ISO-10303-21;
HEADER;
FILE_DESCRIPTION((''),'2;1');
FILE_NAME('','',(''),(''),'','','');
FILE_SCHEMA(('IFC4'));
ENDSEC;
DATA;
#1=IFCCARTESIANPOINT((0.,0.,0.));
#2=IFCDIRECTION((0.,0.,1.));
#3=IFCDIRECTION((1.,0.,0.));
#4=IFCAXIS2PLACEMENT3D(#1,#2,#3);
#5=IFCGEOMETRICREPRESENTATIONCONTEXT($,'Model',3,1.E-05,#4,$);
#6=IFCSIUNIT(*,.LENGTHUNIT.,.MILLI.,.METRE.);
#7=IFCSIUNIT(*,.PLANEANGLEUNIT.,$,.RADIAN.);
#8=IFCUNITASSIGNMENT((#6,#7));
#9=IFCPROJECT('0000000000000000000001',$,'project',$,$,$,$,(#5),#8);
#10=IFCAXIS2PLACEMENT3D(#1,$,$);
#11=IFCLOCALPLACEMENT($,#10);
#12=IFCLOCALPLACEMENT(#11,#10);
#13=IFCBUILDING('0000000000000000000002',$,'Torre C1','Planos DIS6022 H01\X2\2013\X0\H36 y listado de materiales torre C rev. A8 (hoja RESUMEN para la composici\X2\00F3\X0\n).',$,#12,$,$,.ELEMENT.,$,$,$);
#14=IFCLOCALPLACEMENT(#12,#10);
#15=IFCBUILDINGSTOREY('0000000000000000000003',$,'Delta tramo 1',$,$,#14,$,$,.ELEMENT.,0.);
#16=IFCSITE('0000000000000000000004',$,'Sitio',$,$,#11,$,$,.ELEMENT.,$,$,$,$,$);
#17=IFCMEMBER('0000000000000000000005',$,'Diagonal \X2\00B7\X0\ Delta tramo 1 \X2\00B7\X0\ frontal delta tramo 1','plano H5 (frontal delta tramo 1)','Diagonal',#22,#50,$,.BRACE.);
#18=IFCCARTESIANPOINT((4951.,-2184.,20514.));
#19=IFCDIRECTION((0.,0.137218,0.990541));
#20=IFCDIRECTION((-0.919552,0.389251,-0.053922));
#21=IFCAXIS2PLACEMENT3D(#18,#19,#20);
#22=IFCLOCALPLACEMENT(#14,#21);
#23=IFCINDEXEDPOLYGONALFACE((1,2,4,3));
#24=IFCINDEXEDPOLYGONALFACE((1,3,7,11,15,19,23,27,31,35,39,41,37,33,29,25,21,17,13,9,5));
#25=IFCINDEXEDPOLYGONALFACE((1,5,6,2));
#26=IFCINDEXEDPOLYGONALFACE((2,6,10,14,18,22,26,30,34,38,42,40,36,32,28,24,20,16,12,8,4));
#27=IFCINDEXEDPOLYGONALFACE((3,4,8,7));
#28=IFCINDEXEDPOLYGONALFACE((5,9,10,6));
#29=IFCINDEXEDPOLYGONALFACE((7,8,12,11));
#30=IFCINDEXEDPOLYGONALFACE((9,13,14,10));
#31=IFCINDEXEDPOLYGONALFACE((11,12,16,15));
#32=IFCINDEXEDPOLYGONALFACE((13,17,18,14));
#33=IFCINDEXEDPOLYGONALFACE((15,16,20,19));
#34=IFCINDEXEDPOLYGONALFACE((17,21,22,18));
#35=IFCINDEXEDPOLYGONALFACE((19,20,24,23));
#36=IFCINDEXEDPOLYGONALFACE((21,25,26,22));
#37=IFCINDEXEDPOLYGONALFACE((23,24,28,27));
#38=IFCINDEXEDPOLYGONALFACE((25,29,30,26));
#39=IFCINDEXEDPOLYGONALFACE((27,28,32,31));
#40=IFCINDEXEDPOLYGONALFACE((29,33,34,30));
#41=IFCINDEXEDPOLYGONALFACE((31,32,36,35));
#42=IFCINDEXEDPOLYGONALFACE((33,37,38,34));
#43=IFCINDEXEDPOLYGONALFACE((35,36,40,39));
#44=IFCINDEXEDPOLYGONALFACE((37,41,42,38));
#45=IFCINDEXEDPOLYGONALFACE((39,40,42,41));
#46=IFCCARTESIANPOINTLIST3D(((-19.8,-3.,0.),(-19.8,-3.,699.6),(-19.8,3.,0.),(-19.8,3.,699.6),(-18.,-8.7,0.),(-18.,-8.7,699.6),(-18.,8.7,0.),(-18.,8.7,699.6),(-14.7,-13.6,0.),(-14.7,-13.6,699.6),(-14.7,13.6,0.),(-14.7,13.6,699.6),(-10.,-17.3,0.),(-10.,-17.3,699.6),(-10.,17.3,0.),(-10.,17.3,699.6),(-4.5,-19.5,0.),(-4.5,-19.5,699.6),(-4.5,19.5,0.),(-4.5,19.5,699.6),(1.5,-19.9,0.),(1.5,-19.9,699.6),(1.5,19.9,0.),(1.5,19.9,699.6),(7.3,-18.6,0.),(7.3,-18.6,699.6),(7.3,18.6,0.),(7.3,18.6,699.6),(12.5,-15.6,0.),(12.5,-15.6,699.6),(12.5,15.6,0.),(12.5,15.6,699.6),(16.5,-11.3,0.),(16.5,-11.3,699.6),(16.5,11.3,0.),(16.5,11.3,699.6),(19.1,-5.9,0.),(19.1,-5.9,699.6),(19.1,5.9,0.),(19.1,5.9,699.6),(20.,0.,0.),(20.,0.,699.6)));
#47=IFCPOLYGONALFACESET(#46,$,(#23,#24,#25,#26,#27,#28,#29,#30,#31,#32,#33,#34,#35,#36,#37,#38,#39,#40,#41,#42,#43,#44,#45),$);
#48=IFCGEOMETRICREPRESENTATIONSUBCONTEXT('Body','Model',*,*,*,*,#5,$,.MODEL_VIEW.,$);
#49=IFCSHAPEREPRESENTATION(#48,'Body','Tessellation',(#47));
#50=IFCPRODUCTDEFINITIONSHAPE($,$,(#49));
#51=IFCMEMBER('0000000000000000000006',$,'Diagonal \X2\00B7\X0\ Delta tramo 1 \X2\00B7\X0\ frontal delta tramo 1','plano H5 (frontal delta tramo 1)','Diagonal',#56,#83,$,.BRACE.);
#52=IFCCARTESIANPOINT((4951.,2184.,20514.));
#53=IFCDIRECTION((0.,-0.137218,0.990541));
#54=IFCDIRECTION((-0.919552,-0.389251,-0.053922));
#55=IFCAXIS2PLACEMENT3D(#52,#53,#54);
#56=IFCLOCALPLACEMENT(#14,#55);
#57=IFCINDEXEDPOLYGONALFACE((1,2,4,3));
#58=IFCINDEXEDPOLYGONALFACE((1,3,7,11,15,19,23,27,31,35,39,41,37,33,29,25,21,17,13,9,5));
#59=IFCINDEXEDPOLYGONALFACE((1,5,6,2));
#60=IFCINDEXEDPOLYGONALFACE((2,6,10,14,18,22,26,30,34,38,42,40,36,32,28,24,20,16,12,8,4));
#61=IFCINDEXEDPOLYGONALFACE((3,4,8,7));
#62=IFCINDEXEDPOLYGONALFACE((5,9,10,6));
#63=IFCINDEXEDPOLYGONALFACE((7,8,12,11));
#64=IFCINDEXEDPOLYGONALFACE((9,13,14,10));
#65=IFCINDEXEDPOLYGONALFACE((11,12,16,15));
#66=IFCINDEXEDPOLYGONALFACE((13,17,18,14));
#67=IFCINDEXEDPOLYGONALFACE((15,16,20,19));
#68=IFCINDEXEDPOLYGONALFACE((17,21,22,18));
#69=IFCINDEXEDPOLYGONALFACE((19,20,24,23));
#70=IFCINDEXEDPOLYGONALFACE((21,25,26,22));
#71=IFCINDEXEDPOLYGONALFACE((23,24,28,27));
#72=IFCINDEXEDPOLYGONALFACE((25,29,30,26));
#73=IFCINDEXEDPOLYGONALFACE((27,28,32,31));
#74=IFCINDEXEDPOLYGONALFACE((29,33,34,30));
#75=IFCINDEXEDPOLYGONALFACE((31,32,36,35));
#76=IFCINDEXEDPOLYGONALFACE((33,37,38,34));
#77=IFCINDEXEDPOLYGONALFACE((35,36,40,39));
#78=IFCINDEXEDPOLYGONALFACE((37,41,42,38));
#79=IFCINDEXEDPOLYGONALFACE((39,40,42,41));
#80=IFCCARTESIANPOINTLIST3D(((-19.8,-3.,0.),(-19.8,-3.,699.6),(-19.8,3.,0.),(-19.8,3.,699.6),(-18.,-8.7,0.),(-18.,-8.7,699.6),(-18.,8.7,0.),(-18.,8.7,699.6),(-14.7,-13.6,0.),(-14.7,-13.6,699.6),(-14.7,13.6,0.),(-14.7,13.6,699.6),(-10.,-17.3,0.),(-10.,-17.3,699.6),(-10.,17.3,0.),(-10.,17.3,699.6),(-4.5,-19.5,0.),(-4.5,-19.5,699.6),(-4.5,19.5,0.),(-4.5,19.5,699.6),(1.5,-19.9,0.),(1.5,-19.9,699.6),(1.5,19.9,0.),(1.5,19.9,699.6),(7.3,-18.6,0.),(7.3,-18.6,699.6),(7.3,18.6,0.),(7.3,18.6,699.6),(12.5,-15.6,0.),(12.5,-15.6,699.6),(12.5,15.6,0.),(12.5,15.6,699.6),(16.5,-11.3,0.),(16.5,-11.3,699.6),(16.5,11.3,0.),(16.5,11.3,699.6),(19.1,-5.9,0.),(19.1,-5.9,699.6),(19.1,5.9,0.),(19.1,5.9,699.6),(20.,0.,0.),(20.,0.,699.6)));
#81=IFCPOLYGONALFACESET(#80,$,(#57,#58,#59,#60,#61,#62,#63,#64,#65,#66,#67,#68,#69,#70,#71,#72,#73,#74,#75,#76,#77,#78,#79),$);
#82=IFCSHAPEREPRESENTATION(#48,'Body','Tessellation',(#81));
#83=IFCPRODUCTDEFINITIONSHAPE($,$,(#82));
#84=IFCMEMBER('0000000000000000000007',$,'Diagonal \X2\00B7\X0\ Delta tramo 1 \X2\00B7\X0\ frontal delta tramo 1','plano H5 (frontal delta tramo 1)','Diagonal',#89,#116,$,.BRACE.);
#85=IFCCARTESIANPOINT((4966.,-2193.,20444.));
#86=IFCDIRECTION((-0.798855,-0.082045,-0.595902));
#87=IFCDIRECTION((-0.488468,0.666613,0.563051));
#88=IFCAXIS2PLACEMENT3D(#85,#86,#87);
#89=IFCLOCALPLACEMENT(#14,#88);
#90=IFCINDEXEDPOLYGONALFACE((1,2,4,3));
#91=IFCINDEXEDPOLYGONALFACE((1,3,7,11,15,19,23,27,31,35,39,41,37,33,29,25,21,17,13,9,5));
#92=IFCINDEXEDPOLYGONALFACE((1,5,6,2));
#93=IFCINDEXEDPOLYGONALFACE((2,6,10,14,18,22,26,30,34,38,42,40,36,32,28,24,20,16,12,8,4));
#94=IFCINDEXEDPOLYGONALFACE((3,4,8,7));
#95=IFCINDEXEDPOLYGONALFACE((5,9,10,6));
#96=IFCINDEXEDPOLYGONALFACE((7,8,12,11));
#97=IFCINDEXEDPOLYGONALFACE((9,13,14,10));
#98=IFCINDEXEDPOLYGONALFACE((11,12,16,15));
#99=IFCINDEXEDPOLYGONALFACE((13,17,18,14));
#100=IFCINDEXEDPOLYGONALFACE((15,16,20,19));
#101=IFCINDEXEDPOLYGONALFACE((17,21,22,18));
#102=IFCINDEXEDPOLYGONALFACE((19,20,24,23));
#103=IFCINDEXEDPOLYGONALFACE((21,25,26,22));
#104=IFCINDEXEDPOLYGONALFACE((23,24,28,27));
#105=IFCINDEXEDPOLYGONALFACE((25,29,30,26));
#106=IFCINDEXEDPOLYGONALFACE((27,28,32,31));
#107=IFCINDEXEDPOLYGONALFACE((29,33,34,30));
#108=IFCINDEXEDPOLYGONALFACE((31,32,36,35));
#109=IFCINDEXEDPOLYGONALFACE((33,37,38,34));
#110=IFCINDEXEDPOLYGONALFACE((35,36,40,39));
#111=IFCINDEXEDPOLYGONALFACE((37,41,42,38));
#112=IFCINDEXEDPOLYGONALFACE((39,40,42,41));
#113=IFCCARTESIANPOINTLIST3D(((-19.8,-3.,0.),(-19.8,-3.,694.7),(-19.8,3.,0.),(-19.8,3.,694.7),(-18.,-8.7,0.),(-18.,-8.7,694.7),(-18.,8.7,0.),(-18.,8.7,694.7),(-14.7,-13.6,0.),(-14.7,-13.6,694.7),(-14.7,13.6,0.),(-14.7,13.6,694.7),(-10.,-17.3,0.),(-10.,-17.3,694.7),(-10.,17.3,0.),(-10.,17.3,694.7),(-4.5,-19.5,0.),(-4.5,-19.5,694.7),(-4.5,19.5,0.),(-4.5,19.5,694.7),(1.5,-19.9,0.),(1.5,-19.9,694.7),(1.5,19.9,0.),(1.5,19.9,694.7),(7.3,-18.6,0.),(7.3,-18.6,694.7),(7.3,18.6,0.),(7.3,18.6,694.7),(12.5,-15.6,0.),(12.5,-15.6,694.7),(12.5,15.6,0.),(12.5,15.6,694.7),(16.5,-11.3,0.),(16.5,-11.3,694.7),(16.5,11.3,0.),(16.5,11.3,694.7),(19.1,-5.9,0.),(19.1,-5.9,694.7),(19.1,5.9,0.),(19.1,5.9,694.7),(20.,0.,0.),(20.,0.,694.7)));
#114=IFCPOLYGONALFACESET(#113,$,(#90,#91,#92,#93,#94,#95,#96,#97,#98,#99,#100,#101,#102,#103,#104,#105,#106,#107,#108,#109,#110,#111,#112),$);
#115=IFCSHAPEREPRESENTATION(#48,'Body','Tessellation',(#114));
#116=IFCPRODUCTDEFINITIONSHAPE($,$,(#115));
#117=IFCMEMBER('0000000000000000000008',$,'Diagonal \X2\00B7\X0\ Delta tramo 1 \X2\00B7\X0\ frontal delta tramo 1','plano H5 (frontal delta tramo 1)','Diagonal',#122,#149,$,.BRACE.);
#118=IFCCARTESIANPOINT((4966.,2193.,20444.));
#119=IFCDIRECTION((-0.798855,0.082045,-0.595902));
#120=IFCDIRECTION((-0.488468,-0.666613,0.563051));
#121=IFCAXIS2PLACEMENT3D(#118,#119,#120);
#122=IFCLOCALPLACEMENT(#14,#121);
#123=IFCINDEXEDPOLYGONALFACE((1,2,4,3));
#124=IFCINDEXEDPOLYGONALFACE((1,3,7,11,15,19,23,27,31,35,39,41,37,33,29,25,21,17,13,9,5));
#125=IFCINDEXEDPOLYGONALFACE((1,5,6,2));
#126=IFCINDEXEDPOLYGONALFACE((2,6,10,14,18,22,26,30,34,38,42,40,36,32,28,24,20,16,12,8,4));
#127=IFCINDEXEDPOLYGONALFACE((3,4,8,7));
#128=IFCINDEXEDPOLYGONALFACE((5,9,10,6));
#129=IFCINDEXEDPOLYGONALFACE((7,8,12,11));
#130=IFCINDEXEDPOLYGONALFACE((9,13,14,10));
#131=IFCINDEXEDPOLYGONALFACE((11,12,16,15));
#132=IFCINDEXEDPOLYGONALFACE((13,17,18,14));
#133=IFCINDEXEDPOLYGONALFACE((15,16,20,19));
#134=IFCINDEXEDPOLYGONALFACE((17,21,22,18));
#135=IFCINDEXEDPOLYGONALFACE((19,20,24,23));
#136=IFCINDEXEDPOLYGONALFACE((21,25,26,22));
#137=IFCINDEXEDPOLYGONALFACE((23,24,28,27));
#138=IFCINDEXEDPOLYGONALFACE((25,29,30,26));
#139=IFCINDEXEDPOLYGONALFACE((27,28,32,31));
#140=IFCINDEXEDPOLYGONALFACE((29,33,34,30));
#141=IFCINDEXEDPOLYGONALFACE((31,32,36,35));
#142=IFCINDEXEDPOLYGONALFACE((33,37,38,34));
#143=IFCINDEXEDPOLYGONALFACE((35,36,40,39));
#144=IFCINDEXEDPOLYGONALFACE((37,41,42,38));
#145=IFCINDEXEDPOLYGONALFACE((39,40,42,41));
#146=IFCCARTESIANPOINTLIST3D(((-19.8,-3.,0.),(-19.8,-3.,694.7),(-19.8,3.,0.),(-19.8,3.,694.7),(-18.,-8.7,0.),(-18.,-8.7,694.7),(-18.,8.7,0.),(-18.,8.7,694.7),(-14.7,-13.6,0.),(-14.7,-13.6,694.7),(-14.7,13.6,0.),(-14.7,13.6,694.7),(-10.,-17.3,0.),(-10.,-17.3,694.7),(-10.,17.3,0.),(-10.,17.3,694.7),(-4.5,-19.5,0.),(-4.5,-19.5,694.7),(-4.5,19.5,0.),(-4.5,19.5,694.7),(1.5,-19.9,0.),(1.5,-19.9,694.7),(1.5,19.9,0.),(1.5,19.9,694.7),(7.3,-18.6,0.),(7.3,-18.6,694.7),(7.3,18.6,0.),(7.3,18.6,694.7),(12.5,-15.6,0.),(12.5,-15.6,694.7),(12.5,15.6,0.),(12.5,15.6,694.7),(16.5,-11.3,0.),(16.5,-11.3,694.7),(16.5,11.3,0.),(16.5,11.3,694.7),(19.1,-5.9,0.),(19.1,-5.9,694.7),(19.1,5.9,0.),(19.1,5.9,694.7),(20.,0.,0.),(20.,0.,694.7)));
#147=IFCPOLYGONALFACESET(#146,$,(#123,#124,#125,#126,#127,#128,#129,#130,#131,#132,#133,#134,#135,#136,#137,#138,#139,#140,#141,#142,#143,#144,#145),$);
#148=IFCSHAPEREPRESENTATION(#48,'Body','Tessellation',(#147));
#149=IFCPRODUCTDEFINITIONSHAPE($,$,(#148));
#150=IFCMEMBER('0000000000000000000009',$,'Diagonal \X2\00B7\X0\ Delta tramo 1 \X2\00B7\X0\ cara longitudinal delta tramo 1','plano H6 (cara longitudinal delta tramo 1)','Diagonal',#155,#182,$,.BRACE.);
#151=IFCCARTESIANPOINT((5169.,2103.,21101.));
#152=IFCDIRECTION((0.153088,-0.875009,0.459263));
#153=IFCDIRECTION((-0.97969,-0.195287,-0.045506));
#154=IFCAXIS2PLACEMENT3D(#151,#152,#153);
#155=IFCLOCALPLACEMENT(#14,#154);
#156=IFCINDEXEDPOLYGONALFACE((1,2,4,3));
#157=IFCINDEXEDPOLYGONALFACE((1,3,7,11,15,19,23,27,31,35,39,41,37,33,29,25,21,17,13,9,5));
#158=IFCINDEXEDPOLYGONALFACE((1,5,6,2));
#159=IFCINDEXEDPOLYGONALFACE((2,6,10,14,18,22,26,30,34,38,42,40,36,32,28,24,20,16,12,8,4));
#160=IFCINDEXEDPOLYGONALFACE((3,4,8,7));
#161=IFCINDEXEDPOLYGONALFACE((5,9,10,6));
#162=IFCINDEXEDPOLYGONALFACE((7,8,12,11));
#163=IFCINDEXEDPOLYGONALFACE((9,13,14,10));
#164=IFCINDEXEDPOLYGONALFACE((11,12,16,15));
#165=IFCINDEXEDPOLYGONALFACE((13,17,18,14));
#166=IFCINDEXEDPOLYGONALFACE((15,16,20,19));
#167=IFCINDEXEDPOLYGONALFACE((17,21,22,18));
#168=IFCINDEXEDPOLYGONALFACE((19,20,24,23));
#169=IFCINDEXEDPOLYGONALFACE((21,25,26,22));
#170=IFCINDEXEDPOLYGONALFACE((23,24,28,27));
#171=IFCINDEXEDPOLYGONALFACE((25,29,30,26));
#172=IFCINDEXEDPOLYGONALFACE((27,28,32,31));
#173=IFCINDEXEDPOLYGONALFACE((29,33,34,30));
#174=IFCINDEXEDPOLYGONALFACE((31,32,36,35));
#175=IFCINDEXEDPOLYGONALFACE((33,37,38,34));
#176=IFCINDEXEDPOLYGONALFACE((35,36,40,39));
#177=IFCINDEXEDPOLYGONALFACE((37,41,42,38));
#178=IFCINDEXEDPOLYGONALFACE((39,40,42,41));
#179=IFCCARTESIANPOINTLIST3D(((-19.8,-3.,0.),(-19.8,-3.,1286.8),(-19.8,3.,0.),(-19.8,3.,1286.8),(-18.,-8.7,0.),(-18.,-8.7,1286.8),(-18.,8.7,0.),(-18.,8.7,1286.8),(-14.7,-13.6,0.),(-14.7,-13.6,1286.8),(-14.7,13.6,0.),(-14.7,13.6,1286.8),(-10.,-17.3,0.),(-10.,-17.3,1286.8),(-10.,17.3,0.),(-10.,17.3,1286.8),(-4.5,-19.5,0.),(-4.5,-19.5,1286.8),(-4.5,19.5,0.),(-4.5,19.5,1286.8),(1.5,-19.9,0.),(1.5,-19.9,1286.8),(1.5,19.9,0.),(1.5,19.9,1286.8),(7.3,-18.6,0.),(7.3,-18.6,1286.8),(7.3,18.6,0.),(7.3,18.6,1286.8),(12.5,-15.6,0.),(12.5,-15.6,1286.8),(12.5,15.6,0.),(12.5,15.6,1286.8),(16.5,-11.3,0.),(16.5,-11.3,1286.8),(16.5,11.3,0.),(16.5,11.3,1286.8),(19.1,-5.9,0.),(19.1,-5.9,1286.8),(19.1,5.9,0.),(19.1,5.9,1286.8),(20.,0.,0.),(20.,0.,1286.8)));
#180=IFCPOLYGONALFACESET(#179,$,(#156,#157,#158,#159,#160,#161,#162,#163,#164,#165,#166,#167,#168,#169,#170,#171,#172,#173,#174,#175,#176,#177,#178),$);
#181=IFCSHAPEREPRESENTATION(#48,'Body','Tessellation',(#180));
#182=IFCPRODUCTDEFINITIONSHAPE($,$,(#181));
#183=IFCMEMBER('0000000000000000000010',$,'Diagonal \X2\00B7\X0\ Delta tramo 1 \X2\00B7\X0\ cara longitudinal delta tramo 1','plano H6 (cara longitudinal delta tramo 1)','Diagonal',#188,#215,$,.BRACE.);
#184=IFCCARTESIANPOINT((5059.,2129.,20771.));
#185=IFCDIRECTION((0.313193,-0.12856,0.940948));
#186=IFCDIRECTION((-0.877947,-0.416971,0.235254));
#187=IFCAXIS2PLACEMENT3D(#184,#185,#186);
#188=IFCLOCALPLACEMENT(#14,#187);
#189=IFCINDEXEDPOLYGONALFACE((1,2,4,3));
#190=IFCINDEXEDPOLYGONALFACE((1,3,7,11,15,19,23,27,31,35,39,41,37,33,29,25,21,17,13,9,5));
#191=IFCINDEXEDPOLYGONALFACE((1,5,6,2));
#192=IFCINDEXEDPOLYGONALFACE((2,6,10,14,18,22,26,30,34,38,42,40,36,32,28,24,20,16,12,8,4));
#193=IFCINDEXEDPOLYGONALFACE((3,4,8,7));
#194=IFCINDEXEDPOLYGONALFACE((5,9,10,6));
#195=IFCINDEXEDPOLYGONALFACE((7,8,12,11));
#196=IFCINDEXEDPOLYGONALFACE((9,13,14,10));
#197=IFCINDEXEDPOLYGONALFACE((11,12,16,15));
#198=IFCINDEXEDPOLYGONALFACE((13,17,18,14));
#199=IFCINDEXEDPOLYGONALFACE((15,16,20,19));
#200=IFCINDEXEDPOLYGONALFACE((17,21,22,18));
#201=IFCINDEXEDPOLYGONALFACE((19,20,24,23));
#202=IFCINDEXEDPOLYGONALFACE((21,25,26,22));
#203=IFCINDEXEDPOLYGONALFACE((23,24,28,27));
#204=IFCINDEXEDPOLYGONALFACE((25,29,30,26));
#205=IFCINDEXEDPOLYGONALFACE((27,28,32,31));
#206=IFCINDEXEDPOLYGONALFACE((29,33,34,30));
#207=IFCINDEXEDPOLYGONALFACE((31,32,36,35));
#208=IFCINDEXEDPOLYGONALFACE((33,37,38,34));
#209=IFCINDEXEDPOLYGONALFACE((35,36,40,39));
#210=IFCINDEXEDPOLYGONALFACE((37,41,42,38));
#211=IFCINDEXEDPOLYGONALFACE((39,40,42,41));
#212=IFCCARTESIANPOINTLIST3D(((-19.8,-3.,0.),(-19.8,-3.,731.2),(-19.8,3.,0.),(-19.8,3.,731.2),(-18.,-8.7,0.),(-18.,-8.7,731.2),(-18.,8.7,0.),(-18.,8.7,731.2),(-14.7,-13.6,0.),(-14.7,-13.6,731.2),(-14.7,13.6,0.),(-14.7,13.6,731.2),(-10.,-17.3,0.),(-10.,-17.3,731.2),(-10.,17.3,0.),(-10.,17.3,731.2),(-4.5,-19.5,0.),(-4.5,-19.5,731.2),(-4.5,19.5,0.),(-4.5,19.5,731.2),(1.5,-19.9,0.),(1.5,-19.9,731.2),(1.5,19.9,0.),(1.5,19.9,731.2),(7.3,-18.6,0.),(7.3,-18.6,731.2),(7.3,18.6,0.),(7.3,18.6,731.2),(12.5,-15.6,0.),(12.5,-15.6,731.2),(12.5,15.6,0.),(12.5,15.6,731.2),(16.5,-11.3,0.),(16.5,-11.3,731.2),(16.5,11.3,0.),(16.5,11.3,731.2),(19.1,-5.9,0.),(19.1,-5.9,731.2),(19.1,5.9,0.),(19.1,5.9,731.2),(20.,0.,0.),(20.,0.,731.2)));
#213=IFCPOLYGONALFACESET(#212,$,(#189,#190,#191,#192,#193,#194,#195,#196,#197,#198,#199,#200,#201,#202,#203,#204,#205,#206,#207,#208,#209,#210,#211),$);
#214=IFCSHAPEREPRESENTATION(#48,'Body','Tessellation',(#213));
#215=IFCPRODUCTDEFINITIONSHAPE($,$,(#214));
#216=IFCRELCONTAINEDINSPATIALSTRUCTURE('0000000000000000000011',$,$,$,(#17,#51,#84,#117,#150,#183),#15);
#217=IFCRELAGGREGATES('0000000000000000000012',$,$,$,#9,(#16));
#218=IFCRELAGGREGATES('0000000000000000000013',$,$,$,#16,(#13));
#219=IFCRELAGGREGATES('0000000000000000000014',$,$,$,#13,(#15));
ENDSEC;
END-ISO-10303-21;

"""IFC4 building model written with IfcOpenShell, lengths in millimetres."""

from ifc_helpers import new_model, si_unit, frame, origin, origin_with_axes, place, context, subcontext, project, spatial, circle, extrude, element, save


model = new_model("IFC4")

# Units and contexts
model_context = context("Model", 3, precision=1e-05, world=origin_with_axes())
body_context = subcontext(model_context, "Body", "Model", "MODEL_VIEW")
ifc_project = project(units=[si_unit("LENGTHUNIT", "METRE", prefix="MILLI"), si_unit("PLANEANGLEUNIT", "RADIAN")], contexts=[model_context])

# Site, building, storey
site_placement = place(None, origin())
site = spatial("IfcSite", under=ifc_project, at=site_placement, Name="Sitio", CompositionType="ELEMENT")
building_placement = place(site_placement, origin())
building = spatial("IfcBuilding", under=site, at=building_placement, Name="Torre C1", Description="Planos DIS6022 H01–H36 y listado de materiales torre C rev. A8 (hoja RESUMEN para la composición).", CompositionType="ELEMENT")
storey_placement = place(building_placement, origin())
storey = spatial("IfcBuildingStorey", under=building, at=storey_placement, Name="Delta tramo 1", CompositionType="ELEMENT", Elevation=0.0)

# Members
for number, where, z_axis, x_axis, name in (
    (1, (4951.0, -2184.0, 20514.0), (0.0, 0.137218, 0.990541), (-0.919552, 0.389251, -0.053922), "Diagonal · Delta tramo 1 · frontal delta tramo 1"),
    (2, (4951.0, 2184.0, 20514.0), (0.0, -0.137218, 0.990541), (-0.919552, -0.389251, -0.053922), "Diagonal · Delta tramo 1 · frontal delta tramo 1"),
):
    element("IfcMember", number, at=place(storey_placement, frame(where, z_axis=z_axis, x_axis=x_axis)), inside=storey, Name=name, Description="plano H5 (frontal delta tramo 1)", ObjectType="Diagonal", PredefinedType="BRACE", context=body_context, shape_type="SweptSolid", body=[
        extrude(circle(Radius=20.0), None, (0.0, 0.0, 1.0), 699.6),
    ])
for number, where, z_axis, x_axis, name in (
    (3, (4966.0, -2193.0, 20444.0), (-0.798855, -0.082045, -0.595902), (-0.488468, 0.666613, 0.563051), "Diagonal · Delta tramo 1 · frontal delta tramo 1"),
    (4, (4966.0, 2193.0, 20444.0), (-0.798855, 0.082045, -0.595902), (-0.488468, -0.666613, 0.563051), "Diagonal · Delta tramo 1 · frontal delta tramo 1"),
):
    element("IfcMember", number, at=place(storey_placement, frame(where, z_axis=z_axis, x_axis=x_axis)), inside=storey, Name=name, Description="plano H5 (frontal delta tramo 1)", ObjectType="Diagonal", PredefinedType="BRACE", context=body_context, shape_type="SweptSolid", body=[
        extrude(circle(Radius=20.0), None, (0.0, 0.0, 1.0), 694.7),
    ])
member_1_placement = place(storey_placement, frame((5169.0, 2103.0, 21101.0), z_axis=(0.153088, -0.875009, 0.459263), x_axis=(-0.97969, -0.195287, -0.045506)))
element("IfcMember", 5, at=member_1_placement, inside=storey, Name="Diagonal · Delta tramo 1 · cara longitudinal delta tramo 1", Description="plano H6 (cara longitudinal delta tramo 1)", ObjectType="Diagonal", PredefinedType="BRACE", context=body_context, shape_type="SweptSolid", body=[
    extrude(circle(Radius=20.0), None, (0.0, 0.0, 1.0), 1286.8),
])
member_2_placement = place(storey_placement, frame((5059.0, 2129.0, 20771.0), z_axis=(0.313193, -0.12856, 0.940948), x_axis=(-0.877947, -0.416971, 0.235254)))
element("IfcMember", 6, at=member_2_placement, inside=storey, Name="Diagonal · Delta tramo 1 · cara longitudinal delta tramo 1", Description="plano H6 (cara longitudinal delta tramo 1)", ObjectType="Diagonal", PredefinedType="BRACE", context=body_context, shape_type="SweptSolid", body=[
    extrude(circle(Radius=20.0), None, (0.0, 0.0, 1.0), 731.2),
])

save(model, "model.ifc")
